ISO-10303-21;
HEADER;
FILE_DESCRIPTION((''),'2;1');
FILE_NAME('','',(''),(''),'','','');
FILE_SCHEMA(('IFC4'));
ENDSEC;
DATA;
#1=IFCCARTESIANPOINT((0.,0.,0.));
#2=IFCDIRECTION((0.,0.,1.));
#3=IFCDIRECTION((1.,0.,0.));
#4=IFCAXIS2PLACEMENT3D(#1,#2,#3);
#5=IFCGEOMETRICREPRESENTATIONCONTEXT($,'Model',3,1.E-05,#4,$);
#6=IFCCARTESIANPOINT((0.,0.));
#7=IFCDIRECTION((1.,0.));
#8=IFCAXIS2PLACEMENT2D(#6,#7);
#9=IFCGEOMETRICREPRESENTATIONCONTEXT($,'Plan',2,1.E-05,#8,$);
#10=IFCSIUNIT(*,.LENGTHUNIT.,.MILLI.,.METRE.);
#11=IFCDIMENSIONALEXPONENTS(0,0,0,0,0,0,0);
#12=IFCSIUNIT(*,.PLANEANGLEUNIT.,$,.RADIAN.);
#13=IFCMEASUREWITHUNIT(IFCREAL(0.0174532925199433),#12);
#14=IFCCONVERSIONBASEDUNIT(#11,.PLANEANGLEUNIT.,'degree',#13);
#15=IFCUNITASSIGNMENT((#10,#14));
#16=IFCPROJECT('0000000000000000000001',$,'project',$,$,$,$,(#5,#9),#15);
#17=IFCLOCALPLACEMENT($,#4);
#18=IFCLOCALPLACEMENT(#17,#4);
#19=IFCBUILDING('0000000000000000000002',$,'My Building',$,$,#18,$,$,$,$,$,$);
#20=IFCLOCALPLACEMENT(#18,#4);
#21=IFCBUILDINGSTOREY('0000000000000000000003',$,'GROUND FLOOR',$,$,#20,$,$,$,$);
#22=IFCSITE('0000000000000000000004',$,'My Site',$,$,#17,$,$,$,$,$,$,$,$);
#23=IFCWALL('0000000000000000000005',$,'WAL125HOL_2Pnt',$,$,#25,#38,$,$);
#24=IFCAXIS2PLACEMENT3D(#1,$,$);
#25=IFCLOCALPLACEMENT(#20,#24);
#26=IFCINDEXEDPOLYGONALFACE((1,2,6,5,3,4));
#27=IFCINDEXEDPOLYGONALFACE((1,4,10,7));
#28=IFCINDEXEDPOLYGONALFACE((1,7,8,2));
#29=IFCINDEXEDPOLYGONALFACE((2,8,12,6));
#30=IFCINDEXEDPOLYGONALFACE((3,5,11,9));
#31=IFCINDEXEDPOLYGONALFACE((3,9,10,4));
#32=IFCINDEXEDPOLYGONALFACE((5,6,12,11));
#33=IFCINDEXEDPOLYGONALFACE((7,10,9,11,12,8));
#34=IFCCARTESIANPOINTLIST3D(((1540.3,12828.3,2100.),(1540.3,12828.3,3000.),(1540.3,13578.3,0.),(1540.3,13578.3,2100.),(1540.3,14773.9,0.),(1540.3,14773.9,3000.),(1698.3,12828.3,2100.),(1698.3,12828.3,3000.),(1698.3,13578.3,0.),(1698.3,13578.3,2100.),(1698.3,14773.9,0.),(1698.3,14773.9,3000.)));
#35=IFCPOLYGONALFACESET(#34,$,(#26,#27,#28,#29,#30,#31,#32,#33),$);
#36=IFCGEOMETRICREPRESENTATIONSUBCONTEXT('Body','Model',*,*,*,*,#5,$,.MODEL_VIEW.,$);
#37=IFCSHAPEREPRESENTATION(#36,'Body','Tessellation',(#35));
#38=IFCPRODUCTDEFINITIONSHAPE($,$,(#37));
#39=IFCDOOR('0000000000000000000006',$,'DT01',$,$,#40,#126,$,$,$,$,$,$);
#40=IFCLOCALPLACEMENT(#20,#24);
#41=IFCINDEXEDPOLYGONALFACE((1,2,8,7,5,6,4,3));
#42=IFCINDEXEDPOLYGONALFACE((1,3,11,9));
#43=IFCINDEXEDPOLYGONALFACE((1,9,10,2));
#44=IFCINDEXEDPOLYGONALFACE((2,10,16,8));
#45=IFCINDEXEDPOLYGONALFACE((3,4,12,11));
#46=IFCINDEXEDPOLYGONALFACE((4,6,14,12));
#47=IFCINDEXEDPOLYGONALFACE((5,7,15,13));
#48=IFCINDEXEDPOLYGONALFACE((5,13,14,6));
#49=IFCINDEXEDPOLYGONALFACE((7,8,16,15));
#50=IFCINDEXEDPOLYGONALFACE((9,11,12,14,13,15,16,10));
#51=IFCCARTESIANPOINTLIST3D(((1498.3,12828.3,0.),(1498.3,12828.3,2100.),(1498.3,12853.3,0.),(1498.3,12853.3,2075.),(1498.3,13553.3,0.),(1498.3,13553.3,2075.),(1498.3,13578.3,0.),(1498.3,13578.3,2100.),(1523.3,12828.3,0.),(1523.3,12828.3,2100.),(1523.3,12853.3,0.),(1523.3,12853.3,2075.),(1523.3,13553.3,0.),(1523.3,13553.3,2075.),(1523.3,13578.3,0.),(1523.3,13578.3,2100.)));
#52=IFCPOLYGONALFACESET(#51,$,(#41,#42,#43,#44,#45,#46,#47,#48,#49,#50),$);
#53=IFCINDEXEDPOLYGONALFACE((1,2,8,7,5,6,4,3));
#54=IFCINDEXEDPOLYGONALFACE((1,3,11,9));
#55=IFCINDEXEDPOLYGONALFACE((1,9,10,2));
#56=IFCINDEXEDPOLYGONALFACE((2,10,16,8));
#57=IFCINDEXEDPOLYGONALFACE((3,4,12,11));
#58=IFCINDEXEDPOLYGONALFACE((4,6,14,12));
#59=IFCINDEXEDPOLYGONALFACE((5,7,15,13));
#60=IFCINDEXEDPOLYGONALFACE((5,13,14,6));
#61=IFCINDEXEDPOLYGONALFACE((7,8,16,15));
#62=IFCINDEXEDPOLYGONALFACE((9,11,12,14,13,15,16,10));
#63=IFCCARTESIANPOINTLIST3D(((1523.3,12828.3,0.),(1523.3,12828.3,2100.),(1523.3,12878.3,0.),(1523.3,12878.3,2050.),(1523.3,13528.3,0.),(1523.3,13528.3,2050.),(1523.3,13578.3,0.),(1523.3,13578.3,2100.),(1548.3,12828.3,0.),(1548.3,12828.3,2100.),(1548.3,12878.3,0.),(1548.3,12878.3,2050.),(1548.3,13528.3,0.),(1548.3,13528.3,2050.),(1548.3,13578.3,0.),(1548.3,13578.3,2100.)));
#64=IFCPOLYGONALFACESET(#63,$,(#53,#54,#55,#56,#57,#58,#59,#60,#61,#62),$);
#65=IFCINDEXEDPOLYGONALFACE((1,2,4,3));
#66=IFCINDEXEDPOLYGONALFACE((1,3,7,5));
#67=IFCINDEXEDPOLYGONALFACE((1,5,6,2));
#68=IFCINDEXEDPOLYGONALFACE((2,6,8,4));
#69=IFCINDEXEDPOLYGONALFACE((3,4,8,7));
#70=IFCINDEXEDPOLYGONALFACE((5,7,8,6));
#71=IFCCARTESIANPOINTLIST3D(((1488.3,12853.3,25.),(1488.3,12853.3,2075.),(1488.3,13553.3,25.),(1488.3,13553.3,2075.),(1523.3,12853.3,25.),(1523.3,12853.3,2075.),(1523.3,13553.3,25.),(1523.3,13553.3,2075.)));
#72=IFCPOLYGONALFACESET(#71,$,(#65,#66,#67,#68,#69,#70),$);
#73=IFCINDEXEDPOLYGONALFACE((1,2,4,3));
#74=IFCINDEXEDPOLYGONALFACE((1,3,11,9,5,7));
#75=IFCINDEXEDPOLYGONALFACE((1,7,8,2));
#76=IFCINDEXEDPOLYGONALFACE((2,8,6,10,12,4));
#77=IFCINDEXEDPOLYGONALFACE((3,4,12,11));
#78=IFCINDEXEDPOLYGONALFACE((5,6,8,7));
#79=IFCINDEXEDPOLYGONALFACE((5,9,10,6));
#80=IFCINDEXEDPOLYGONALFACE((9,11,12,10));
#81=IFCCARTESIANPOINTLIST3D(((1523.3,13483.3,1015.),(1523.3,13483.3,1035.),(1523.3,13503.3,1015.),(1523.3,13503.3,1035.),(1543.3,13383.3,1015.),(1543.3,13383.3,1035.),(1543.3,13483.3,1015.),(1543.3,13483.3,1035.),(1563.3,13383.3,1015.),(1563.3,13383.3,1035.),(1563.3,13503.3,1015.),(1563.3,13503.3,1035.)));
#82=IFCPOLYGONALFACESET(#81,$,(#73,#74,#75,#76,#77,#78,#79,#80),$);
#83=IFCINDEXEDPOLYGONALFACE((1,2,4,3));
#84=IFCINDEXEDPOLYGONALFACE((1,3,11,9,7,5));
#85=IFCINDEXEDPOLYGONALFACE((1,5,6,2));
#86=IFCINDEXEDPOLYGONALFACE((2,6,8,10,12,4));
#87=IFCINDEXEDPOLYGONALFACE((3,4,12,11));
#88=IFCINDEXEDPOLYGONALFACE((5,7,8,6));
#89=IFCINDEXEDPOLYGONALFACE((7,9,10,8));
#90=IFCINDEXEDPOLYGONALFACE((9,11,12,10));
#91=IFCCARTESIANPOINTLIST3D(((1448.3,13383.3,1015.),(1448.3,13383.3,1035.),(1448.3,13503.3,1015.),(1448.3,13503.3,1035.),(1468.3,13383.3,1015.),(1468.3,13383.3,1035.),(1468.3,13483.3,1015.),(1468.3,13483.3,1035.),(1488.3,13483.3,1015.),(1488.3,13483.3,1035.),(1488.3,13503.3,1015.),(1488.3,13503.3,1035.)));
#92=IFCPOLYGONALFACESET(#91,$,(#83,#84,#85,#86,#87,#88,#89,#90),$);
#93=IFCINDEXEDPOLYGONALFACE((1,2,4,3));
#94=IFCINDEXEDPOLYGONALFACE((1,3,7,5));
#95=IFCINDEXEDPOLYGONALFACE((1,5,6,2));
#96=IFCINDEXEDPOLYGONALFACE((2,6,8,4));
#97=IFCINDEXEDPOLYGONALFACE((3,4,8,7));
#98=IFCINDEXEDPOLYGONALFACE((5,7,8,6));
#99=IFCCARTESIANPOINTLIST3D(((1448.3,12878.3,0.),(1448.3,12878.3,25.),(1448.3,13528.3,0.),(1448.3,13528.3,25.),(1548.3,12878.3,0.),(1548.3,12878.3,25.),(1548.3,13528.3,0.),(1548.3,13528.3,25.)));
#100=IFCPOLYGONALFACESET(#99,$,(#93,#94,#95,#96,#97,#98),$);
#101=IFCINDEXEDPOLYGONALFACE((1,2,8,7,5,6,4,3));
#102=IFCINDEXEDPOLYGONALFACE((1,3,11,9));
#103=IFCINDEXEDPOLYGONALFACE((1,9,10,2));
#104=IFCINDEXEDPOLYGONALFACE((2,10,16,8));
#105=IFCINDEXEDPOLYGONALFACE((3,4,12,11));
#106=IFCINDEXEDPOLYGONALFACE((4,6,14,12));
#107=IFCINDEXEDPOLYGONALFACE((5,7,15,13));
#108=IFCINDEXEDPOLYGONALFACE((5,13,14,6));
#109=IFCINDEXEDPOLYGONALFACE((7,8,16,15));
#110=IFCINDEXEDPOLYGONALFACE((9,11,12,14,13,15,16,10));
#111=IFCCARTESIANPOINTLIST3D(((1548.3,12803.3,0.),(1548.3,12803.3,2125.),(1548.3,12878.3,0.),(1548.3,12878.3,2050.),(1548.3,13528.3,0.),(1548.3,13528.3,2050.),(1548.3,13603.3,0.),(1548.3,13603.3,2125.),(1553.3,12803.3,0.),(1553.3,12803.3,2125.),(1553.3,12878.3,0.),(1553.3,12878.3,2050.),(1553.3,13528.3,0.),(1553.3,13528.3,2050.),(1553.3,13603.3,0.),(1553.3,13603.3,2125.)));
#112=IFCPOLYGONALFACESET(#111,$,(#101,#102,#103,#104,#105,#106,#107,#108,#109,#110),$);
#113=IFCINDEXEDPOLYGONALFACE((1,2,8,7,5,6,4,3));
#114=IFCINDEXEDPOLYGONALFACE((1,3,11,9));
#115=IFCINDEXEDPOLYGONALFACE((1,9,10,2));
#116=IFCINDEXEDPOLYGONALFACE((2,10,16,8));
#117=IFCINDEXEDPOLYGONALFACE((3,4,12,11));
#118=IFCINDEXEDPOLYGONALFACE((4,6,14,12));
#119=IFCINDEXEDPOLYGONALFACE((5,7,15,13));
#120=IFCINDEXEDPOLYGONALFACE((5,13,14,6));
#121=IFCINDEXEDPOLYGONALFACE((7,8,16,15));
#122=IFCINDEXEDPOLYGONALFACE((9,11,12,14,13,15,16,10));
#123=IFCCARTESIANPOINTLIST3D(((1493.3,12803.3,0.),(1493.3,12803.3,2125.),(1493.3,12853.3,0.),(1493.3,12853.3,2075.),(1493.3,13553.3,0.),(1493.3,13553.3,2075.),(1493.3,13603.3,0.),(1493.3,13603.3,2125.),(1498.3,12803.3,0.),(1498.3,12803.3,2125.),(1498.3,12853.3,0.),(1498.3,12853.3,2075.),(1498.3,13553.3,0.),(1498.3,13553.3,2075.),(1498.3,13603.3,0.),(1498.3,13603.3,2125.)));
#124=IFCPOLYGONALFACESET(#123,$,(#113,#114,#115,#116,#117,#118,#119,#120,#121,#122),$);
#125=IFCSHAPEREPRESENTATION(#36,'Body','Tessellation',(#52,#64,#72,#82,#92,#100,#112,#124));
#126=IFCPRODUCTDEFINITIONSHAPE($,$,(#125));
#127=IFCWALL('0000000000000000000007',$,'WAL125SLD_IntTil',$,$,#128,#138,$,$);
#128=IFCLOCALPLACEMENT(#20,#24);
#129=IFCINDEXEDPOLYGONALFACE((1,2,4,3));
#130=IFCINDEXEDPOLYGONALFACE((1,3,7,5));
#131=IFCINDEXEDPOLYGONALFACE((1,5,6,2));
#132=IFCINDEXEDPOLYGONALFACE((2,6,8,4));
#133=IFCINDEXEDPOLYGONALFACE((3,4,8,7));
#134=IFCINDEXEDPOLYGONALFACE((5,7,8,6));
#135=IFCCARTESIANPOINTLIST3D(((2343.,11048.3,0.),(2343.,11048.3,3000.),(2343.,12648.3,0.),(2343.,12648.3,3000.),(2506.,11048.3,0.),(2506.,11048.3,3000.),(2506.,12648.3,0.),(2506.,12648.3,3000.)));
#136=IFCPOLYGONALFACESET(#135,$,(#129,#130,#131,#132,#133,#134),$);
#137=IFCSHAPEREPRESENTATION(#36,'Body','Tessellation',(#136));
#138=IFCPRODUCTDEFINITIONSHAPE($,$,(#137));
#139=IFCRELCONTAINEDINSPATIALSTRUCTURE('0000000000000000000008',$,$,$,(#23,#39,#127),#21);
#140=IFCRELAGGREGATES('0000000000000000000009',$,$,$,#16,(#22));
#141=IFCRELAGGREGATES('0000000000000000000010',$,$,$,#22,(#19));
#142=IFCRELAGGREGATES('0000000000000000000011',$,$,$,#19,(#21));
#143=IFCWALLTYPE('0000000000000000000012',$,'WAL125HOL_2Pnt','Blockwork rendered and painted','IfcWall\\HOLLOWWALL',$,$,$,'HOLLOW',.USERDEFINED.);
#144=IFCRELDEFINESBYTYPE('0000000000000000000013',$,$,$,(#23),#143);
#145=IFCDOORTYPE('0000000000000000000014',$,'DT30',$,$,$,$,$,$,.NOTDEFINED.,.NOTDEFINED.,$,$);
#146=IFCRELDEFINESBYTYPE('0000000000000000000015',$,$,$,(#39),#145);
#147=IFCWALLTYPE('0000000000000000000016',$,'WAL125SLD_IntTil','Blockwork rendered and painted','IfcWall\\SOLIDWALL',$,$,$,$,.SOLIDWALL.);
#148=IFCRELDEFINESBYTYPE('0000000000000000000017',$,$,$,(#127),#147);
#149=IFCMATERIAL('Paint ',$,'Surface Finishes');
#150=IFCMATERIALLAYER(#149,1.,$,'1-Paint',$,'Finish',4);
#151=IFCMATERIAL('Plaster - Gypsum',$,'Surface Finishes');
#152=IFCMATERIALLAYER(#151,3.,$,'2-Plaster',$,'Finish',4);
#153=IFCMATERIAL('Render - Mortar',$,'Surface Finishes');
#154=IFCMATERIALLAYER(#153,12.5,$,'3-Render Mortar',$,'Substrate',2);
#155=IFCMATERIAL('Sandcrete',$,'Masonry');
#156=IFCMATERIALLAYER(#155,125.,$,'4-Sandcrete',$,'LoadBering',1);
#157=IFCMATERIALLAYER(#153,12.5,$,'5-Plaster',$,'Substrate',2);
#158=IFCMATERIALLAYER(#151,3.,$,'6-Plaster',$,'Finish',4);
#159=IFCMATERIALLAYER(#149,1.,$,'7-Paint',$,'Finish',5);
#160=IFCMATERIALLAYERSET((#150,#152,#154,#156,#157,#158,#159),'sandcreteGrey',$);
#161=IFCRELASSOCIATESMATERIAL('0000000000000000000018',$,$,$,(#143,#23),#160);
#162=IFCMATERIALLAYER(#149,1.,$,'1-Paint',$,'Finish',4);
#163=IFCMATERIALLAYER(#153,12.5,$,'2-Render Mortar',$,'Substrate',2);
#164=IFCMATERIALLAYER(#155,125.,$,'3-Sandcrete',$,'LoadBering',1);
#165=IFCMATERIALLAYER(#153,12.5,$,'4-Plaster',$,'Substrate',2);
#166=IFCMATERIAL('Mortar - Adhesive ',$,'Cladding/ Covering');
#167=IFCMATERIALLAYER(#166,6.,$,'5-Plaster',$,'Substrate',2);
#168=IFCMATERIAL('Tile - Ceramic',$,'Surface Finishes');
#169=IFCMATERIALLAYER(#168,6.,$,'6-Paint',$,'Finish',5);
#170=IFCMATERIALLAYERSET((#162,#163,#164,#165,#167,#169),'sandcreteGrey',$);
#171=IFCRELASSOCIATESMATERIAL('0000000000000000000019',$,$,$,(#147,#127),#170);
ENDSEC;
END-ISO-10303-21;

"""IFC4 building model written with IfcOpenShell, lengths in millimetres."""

from ifc_helpers import new_model, entity, si_unit, converted_unit, frame, origin_with_axes, origin_2d_with_axis, place, context, subcontext, project, spatial, line, indexed_curve, outline, extrude, shape, source, transform, mapped, material, layer, layer_set, layer_usage, type_object, type_shapes, element, fill, save


model = new_model("IFC4")

# Units and contexts
model_context = context("Model", 3, precision=1e-05, world=origin_with_axes())
plan_context = context("Plan", 2, precision=1e-05, world=origin_2d_with_axis())
body_context_1 = subcontext(model_context, "Body", "Model", "MODEL_VIEW")
body_context_2 = subcontext(plan_context, "Body", "Plan", "PLAN_VIEW")
ifc_project = project(units=[si_unit("LENGTHUNIT", "METRE", prefix="MILLI"), converted_unit("PLANEANGLEUNIT", "degree", entity("IfcReal", 0.0174532925199433), si_unit("PLANEANGLEUNIT", "RADIAN"), dimensions=[0, 0, 0, 0, 0, 0, 0])], contexts=[model_context, plan_context])

# Site, building, storey
site_placement = place(None, origin_with_axes())
site = spatial("IfcSite", under=ifc_project, at=site_placement, Name="My Site")
building_placement = place(site_placement, origin_with_axes())
building = spatial("IfcBuilding", under=site, at=building_placement, Name="My Building")
storey_placement = place(building_placement, origin_with_axes())
storey = spatial("IfcBuildingStorey", under=building, at=storey_placement, Name="GROUND FLOOR")

# Wall, opening, door
ifc_material_1 = material(Name="Paint ", Category="Surface Finishes")
ifc_layer_1 = layer(ifc_material_1, 1.0, Name="1-Paint", Category="Finish", Priority=4)
ifc_material_2 = material(Name="Plaster - Gypsum", Category="Surface Finishes")
ifc_layer_2 = layer(ifc_material_2, 3.0, Name="2-Plaster", Category="Finish", Priority=4)
ifc_material_3 = material(Name="Render - Mortar", Category="Surface Finishes")
ifc_layer_3 = layer(ifc_material_3, 12.5, Name="3-Render Mortar", Category="Substrate", Priority=2)
ifc_material_4 = material(Name="Sandcrete", Category="Masonry")
ifc_layer_4 = layer(ifc_material_4, 125.0, Name="4-Sandcrete", Category="LoadBering", Priority=1)
ifc_layer_5 = layer(ifc_material_3, 12.5, Name="5-Plaster", Category="Substrate", Priority=2)
ifc_layer_6 = layer(ifc_material_2, 3.0, Name="6-Plaster", Category="Finish", Priority=4)
ifc_layer_7 = layer(ifc_material_1, 1.0, Name="7-Paint", Category="Finish", Priority=5)
ifc_layer_set_1 = layer_set([ifc_layer_1, ifc_layer_2, ifc_layer_3, ifc_layer_4, ifc_layer_5, ifc_layer_6, ifc_layer_7], Name="sandcreteGrey")
ifc_layer_usage_1 = layer_usage(ifc_layer_set_1, "AXIS2", "POSITIVE", 0.0)
wall_type_1 = type_object("IfcWallType", Name="WAL125HOL_2Pnt", Description="Blockwork rendered and painted", ApplicableOccurrence="IfcWall\\HOLLOWWALL", ElementType="HOLLOW", PredefinedType="USERDEFINED", material=ifc_layer_set_1)
wall_1_placement = place(storey_placement, frame((1540.3, 14773.9, 0.0), z_axis=(0.0, 0.0, 1.0), x_axis=(-0.000001, -1.0, 0.0)))
wall_1 = element("IfcWall", 1, at=wall_1_placement, inside=storey, type_object=wall_type_1, material=ifc_layer_usage_1, Name="WAL125HOL_2Pnt", context=body_context_1, shape_type="SweptSolid", body=[
    extrude(outline(indexed_curve([(0.0, 0.0), (0.0, 158.0), (1945.6, 158.0), (1945.6, 0.0), (0.0, 0.0)], self_intersect=False)), origin_with_axes(), (0.0, 0.0, 1.0), 3000.0),
])
shared_shape_1 = source(origin_with_axes(), body_context_1, "Body", "SweptSolid", [
    extrude(outline(indexed_curve([(0.0, 0.0), (750.0, 0.0), (750.0, 2100.0), (0.0, 2100.0)], segments=[line(1, 2, 3, 4, 1)])), frame((0.0, -100.0, 0.0), z_axis=(0.0, -1.0, 0.0), x_axis=(1.0, 0.0, 0.0)), (0.0, 0.0, -1.0), 380.0),
])
opening_1_placement = place(wall_1_placement, frame((1945.6, 158.0, 0.0), z_axis=(0.0, 0.0, 1.0), x_axis=(-1.0, 0.0, 0.0)))
opening_1 = element("IfcOpeningElement", 2, at=opening_1_placement, cuts=wall_1, PredefinedType="OPENING", context=body_context_1, shape_type="MappedRepresentation", body=[
    mapped(shared_shape_1, transform((0.0, 0.0, 0.0), x_axis=(1.0, 0.0, 0.0), y_axis=(0.0, 1.0, 0.0), z_axis=(0.0, 0.0, 1.0), scale=1.0)),
])
door_type_1 = type_object("IfcDoorType", Name="DT30", OperationType="NOTDEFINED", PredefinedType="NOTDEFINED")
shared_shape_2 = source(origin_with_axes(), body_context_1, "Body", "SweptSolid", [
    extrude(outline(indexed_curve([(0.0, 0.0), (0.0, 2100.0), (750.0, 2100.0), (750.0, 0.0), (725.0, 0.0), (725.0, 2075.0), (25.0, 2075.0), (25.0, 0.0)], segments=[line(1, 2, 3, 4, 5, 6, 7, 8, 1)])), frame((0.0, 25.0, 0.0), z_axis=(0.0, -1.0, 0.0), x_axis=(1.0, 0.0, 0.0)), (0.0, 0.0, -1.0), 25.0),
    extrude(outline(indexed_curve([(0.0, 0.0), (0.0, 2100.0), (750.0, 2100.0), (750.0, 0.0), (700.0, 0.0), (700.0, 2050.0), (50.0, 2050.0), (50.0, 0.0)], segments=[line(1, 2, 3, 4, 5, 6, 7, 8, 1)])), frame((0.0, 0.0, 0.0), z_axis=(0.0, -1.0, 0.0), x_axis=(1.0, 0.0, 0.0)), (0.0, 0.0, -1.0), 25.0),
    extrude(outline(indexed_curve([(0.0, 0.0), (700.0, 0.0), (700.0, 35.0), (0.0, 35.0)], segments=[line(1, 2, 3, 4, 1)])), frame((25.0, 25.0, 25.0), z_axis=(0.0, 0.0, 1.0), x_axis=(1.0, 0.0, 0.0)), (0.0, 0.0, 1.0), 2050.0),
    extrude(outline(indexed_curve([(0.0, 0.0), (0.0, -40.0), (-120.0, -40.0), (-120.0, -20.0), (-20.0, -20.0), (-20.0, 0.0)], segments=[line(1, 2, 3, 4, 5, 6, 1)])), frame((675.0, 25.0, 1015.0), z_axis=(0.0, 0.0, 1.0), x_axis=(1.0, 0.0, 0.0)), (0.0, 0.0, 1.0), 20.0),
    extrude(outline(indexed_curve([(0.0, 0.0), (0.0, 40.0), (-120.0, 40.0), (-120.0, 20.0), (-20.0, 20.0), (-20.0, 0.0)], segments=[line(1, 2, 3, 4, 5, 6, 1)])), frame((675.0, 60.0, 1015.0), z_axis=(0.0, 0.0, 1.0), x_axis=(1.0, 0.0, 0.0)), (0.0, 0.0, 1.0), 20.0),
    extrude(outline(indexed_curve([(0.0, 0.0), (650.0, 0.0), (650.0, 100.0), (0.0, 100.0)], segments=[line(1, 2, 3, 4, 1)])), frame((50.0, 0.0, 0.0), z_axis=(0.0, 0.0, 1.0), x_axis=(1.0, 0.0, 0.0)), (0.0, 0.0, 1.0), 25.0),
    extrude(outline(indexed_curve([(0.0, 0.0), (0.0, 2125.0), (800.0, 2125.0), (800.0, 0.0), (725.0, 0.0), (725.0, 2050.0), (75.0, 2050.0), (75.0, 0.0)], segments=[line(1, 2, 3, 4, 5, 6, 7, 8, 1)])), frame((-25.0, -5.0, 0.0), z_axis=(0.0, -1.0, 0.0), x_axis=(1.0, 0.0, 0.0)), (0.0, 0.0, -1.0), 5.0),
    extrude(outline(indexed_curve([(0.0, 0.0), (0.0, 2125.0), (800.0, 2125.0), (800.0, 0.0), (750.0, 0.0), (750.0, 2075.0), (50.0, 2075.0), (50.0, 0.0)], segments=[line(1, 2, 3, 4, 5, 6, 7, 8, 1)])), frame((-25.0, 50.0, 0.0), z_axis=(0.0, -1.0, 0.0), x_axis=(1.0, 0.0, 0.0)), (0.0, 0.0, -1.0), 5.0),
])
shared_shape_3 = source(origin_with_axes(), body_context_2, "Body", "Curve2D", [
    entity("IfcIndexedPolyCurve", entity("IfcCartesianPointList2D", [[0.0, 0.0], [0.0, 50.0], [25.0, 50.0], [25.0, 25.0], [50.0, 25.0], [50.0, 0.0]]), [entity("IfcLineIndex", [1, 2, 3, 4, 5, 6, 1])]),
    entity("IfcIndexedPolyCurve", entity("IfcCartesianPointList2D", [[750.0, 0.0], [750.0, 50.0], [725.0, 50.0], [725.0, 25.0], [700.0, 25.0], [700.0, 0.0]]), [entity("IfcLineIndex", [1, 2, 3, 4, 5, 6, 1])]),
    entity("IfcTrimmedCurve", entity("IfcEllipse", entity("IfcAxis2Placement2D", entity("IfcCartesianPoint", [60.0, 50.0]), entity("IfcDirection", [1.0, 0.0])), 665.0, 700.0), [entity("IfcCartesianPoint", [725.0, 50.0])], [entity("IfcCartesianPoint", [60.0, 750.0])], True, "CARTESIAN"),
    entity("IfcIndexedPolyCurve", entity("IfcCartesianPointList2D", [[25.0, 50.0], [60.0, 50.0], [60.0, 750.0], [25.0, 750.0]]), [entity("IfcLineIndex", [1, 2, 3, 4, 1])]),
])
type_shapes(door_type_1, [shared_shape_2, shared_shape_3])
door_1_placement = place(opening_1_placement, frame((0.0, 150.0, 0.0), z_axis=(0.0, 0.0, 1.0), x_axis=(1.0, 0.0, 0.0)))
door_1 = element("IfcDoor", 3, at=door_1_placement, inside=storey, type_object=door_type_1, Name="DT01", shapes=[
    shape(body_context_1, "Body", "MappedRepresentation", [mapped(shared_shape_2, transform((0.0, 0.0, 0.0), x_axis=(1.0, 0.0, 0.0), y_axis=(0.0, 1.0, 0.0), z_axis=(0.0, 0.0, 1.0), scale=1.0))]),
    shape(body_context_2, "Body", "MappedRepresentation", [mapped(shared_shape_3, transform((0.0, 0.0, 0.0), x_axis=(1.0, 0.0, 0.0), y_axis=(0.0, 1.0, 0.0), z_axis=(0.0, 0.0, 1.0), scale=1.0))]),
])
fill(opening_1, door_1)

# Wall
ifc_layer_8 = layer(ifc_material_1, 1.0, Name="1-Paint", Category="Finish", Priority=4)
ifc_layer_9 = layer(ifc_material_3, 12.5, Name="2-Render Mortar", Category="Substrate", Priority=2)
ifc_layer_10 = layer(ifc_material_4, 125.0, Name="3-Sandcrete", Category="LoadBering", Priority=1)
ifc_layer_11 = layer(ifc_material_3, 12.5, Name="4-Plaster", Category="Substrate", Priority=2)
ifc_material_5 = material(Name="Mortar - Adhesive ", Category="Cladding/ Covering")
ifc_layer_12 = layer(ifc_material_5, 6.0, Name="5-Plaster", Category="Substrate", Priority=2)
ifc_material_6 = material(Name="Tile - Ceramic", Category="Surface Finishes")
ifc_layer_13 = layer(ifc_material_6, 6.0, Name="6-Paint", Category="Finish", Priority=5)
ifc_layer_set_2 = layer_set([ifc_layer_8, ifc_layer_9, ifc_layer_10, ifc_layer_11, ifc_layer_12, ifc_layer_13], Name="sandcreteGrey")
ifc_layer_usage_2 = layer_usage(ifc_layer_set_2, "AXIS2", "POSITIVE", 0.0)
wall_type_2 = type_object("IfcWallType", Name="WAL125SLD_IntTil", Description="Blockwork rendered and painted", ApplicableOccurrence="IfcWall\\SOLIDWALL", PredefinedType="SOLIDWALL", material=ifc_layer_set_2)
wall_2_placement = place(storey_placement, frame((2506.0, 11048.3, 0.0), z_axis=(0.0, 0.0, 1.0), x_axis=(0.0, 1.0, 0.0)))
element("IfcWall", 4, at=wall_2_placement, inside=storey, type_object=wall_type_2, material=ifc_layer_usage_2, Name="WAL125SLD_IntTil", context=body_context_1, shape_type="SweptSolid", body=[
    extrude(outline(indexed_curve([(0.0, 0.0), (0.0, 163.0), (1600.0, 163.0), (1600.0, 0.0), (0.0, 0.0)], self_intersect=False)), origin_with_axes(), (0.0, 0.0, 1.0), 3000.0),
])

save(model, "model.ifc")
